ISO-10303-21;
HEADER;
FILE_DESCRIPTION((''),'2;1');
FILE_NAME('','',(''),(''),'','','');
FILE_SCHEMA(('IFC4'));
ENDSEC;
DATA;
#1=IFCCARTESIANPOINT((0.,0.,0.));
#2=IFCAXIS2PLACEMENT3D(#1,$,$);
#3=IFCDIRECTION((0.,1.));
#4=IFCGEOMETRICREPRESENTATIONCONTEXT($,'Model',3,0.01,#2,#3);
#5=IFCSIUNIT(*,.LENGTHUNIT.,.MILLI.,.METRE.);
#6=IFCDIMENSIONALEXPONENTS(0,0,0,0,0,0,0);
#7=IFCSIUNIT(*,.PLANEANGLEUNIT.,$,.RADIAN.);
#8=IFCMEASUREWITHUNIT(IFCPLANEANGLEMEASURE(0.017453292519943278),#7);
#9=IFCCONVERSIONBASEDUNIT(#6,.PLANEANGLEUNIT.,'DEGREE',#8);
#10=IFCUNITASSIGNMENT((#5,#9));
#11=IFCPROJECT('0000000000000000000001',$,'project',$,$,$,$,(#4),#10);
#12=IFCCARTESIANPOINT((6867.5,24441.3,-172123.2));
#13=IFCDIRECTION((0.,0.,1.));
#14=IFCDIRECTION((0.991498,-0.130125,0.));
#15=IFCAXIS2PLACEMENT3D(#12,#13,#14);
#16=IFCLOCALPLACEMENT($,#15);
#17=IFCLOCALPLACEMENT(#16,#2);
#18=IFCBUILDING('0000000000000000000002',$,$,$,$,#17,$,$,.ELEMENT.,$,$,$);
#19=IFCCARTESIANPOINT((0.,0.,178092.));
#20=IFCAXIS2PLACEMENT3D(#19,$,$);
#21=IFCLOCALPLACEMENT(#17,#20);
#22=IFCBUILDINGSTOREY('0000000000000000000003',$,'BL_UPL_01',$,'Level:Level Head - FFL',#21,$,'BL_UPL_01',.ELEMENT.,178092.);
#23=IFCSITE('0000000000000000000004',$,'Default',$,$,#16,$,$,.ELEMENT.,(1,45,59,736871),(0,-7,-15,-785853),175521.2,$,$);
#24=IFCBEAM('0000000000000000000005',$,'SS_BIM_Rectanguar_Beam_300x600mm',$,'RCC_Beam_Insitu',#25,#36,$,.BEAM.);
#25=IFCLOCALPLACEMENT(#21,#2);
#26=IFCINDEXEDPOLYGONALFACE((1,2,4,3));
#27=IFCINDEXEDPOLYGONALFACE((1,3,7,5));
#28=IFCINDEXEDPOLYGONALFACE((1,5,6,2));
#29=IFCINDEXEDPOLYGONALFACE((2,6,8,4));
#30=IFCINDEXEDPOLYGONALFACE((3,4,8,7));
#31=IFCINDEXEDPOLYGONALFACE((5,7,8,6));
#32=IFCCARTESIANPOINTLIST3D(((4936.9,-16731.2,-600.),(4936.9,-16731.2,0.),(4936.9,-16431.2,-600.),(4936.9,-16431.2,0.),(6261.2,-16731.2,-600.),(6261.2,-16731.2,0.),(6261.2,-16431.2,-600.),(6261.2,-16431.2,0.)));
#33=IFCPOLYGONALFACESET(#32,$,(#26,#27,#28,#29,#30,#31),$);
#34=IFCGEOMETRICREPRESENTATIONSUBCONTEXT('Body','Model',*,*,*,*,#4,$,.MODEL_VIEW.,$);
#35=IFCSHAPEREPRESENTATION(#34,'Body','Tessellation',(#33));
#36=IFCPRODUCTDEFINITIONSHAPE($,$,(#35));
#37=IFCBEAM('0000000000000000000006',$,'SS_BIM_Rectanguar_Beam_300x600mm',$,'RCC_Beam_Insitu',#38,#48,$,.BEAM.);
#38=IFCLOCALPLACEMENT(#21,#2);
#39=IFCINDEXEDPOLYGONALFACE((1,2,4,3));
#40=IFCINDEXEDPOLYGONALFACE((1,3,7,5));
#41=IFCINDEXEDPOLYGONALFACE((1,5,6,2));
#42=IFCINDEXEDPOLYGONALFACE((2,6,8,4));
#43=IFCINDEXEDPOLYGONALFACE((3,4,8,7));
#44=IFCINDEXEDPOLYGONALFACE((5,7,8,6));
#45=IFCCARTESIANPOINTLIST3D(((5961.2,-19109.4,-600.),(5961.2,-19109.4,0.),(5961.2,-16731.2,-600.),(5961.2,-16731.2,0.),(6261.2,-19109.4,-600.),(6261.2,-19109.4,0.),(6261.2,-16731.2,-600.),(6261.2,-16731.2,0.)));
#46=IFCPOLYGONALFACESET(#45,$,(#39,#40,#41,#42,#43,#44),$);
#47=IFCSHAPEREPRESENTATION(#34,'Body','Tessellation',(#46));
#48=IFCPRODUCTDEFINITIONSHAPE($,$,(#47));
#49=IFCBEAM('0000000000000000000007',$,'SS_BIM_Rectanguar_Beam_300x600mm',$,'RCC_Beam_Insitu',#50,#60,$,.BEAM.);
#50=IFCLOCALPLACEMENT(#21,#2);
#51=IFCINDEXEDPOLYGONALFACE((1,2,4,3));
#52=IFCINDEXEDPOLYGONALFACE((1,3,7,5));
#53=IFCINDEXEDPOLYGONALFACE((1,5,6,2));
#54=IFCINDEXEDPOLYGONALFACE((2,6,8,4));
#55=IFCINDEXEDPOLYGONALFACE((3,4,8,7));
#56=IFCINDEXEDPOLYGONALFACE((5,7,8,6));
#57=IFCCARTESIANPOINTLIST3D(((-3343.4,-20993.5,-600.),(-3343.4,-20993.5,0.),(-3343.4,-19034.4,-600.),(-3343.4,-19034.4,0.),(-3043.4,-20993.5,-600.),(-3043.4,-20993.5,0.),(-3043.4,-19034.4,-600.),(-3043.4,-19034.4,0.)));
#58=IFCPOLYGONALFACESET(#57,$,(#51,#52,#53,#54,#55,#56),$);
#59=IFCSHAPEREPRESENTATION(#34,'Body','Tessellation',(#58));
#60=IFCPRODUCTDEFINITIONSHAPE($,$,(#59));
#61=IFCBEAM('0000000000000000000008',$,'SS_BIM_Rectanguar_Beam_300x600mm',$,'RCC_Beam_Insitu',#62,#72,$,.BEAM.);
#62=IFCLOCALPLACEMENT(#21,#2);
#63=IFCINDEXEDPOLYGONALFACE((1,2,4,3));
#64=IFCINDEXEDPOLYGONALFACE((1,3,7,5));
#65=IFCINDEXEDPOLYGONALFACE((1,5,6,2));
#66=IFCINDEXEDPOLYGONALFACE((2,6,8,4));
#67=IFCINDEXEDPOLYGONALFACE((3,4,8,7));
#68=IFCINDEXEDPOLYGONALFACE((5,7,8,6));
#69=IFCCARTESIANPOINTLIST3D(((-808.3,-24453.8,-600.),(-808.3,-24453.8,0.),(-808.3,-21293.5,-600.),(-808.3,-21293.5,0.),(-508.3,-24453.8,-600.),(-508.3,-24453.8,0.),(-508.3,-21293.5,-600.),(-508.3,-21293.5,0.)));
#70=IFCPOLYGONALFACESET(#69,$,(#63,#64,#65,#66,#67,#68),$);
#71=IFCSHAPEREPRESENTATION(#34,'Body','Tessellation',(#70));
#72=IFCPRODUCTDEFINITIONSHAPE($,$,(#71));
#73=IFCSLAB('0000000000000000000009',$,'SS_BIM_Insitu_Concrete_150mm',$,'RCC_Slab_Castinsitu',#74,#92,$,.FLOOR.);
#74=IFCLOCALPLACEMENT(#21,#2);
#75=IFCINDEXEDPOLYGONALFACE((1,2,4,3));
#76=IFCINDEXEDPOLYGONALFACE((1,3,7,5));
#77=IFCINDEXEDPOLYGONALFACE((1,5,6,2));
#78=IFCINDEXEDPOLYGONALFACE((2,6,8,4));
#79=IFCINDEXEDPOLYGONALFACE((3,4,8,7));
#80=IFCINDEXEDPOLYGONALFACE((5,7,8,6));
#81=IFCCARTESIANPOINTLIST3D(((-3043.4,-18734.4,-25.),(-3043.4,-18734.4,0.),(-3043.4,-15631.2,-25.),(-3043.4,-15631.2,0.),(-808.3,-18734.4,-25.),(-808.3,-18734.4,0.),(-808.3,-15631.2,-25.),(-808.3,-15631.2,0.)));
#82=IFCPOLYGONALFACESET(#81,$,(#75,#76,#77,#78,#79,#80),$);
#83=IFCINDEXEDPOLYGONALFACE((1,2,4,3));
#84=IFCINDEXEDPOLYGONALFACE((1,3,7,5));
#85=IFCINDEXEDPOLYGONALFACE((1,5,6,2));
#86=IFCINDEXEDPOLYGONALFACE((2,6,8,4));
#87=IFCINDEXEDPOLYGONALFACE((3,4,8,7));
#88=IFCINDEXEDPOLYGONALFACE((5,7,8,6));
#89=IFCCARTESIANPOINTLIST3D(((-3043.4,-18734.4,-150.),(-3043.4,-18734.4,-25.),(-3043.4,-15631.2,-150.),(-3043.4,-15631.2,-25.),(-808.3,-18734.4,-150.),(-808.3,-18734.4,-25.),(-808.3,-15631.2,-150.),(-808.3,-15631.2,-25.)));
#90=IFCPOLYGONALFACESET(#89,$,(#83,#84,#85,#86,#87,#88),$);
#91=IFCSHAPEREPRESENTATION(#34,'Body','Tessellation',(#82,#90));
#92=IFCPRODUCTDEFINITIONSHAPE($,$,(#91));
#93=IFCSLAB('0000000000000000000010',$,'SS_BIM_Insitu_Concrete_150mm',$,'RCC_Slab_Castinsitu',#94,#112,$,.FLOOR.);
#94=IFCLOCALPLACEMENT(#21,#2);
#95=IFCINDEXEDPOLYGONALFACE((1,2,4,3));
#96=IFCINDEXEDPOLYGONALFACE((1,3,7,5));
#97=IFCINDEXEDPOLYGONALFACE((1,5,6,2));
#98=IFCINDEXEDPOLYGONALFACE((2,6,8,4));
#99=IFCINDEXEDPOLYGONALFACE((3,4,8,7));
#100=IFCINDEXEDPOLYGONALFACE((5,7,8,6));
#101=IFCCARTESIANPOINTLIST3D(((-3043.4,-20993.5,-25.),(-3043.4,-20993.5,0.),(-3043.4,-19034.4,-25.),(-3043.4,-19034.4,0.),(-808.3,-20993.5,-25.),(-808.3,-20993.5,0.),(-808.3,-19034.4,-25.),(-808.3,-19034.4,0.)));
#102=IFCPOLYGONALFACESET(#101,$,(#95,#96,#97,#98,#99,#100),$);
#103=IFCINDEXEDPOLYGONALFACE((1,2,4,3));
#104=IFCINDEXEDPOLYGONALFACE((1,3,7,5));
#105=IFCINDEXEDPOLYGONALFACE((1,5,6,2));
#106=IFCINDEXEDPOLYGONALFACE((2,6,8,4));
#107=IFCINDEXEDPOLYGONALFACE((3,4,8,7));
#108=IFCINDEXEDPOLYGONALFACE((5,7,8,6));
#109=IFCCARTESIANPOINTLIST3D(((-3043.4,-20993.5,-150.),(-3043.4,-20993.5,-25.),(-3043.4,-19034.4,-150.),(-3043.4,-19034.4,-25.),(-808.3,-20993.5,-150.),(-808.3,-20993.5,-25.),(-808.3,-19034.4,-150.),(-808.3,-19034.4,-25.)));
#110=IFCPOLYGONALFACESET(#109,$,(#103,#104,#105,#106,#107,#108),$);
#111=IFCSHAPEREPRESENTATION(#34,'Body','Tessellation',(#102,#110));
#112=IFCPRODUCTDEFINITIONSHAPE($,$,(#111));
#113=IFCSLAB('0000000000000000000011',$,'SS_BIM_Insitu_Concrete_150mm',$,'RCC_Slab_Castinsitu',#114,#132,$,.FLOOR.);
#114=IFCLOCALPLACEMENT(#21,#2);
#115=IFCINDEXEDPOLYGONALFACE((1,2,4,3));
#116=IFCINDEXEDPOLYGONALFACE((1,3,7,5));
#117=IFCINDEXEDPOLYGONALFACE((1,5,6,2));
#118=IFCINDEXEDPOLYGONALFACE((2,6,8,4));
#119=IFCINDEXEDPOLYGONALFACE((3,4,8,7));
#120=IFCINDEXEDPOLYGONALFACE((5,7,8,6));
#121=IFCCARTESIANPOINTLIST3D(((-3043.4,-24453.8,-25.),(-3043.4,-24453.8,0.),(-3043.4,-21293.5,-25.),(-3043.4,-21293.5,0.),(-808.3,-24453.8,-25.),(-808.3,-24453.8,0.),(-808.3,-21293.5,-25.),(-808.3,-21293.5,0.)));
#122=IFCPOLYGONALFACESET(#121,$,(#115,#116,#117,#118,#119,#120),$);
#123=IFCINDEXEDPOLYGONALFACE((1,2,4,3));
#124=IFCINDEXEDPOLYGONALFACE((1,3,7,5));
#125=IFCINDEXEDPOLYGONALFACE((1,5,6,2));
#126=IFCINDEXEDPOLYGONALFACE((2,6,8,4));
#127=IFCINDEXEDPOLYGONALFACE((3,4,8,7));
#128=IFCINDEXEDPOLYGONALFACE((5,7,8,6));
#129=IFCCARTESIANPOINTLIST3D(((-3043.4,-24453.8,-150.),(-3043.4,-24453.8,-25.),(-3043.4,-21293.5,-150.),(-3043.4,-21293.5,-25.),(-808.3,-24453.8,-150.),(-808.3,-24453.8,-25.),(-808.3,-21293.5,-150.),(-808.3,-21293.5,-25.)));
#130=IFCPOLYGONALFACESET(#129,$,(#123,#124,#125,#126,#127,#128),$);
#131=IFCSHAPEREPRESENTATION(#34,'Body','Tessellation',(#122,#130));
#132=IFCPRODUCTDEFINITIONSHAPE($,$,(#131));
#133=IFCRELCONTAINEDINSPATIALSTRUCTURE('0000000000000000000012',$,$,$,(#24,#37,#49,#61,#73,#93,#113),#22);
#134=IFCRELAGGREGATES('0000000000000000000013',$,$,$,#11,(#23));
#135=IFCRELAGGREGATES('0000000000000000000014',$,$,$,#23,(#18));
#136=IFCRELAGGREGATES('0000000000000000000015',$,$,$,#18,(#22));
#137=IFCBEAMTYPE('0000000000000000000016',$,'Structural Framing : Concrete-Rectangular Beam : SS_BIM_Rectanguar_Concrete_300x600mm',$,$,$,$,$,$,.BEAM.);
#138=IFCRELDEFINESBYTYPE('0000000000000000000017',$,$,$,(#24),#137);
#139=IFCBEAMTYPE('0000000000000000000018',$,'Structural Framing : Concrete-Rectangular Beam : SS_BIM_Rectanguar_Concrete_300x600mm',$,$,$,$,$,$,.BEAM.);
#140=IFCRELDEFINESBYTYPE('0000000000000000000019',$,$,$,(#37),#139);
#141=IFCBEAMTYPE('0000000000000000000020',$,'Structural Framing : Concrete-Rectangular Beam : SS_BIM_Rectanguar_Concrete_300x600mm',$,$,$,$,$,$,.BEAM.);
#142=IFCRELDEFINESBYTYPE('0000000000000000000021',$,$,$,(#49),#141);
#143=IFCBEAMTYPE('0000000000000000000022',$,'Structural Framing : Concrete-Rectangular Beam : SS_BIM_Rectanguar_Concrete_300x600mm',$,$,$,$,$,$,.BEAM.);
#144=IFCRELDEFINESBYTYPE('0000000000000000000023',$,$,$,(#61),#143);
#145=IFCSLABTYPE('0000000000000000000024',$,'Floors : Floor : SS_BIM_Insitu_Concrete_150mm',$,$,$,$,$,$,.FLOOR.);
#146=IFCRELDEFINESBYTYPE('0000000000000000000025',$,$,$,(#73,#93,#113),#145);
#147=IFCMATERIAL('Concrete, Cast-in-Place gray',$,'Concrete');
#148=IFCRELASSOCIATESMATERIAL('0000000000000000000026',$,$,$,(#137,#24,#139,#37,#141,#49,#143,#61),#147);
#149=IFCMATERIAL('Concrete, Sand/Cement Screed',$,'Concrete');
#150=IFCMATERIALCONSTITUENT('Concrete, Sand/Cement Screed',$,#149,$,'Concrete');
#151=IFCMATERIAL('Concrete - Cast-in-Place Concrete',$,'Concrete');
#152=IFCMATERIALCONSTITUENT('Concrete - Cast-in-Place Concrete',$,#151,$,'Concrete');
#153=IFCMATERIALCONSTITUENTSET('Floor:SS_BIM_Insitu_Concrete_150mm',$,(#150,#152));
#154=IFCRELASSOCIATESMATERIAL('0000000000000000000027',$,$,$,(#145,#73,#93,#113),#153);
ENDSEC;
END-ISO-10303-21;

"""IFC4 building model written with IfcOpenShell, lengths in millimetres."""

from ifc_helpers import new_model, entity, si_unit, converted_unit, direction, frame, origin, place, context, subcontext, project, spatial, indexed_curve, outline, extrude, source, transform, mapped, material, constituent, constituent_set, type_object, type_shapes, element, save


model = new_model("IFC4")

# Units and contexts
model_context = context("Model", 3, precision=0.01, world=origin(), true_north=direction((0.0, 1.0)))
body_context = subcontext(model_context, "Body", "Model", "MODEL_VIEW")
ifc_project = project(units=[si_unit("LENGTHUNIT", "METRE", prefix="MILLI"), converted_unit("PLANEANGLEUNIT", "DEGREE", entity("IfcPlaneAngleMeasure", 0.017453292519943278), si_unit("PLANEANGLEUNIT", "RADIAN"), dimensions=[0, 0, 0, 0, 0, 0, 0])], contexts=[model_context])

# Site, building, storey
site_placement = place(None, frame((6867.5, 24441.3, -172123.2), z_axis=(0.0, 0.0, 1.0), x_axis=(0.991498, -0.130125, 0.0)))
site = spatial("IfcSite", under=ifc_project, at=site_placement, Name="Default", CompositionType="ELEMENT", RefLatitude=(1, 45, 59, 736871), RefLongitude=(0, -7, -15, -785853), RefElevation=175521.2)
building_placement = place(site_placement, origin())
building = spatial("IfcBuilding", under=site, at=building_placement, CompositionType="ELEMENT")
storey_placement = place(building_placement, frame((0.0, 0.0, 178092.0)))
storey = spatial("IfcBuildingStorey", under=building, at=storey_placement, Name="BL_UPL_01", ObjectType="Level:Level Head - FFL", LongName="BL_UPL_01", CompositionType="ELEMENT", Elevation=178092.0)

# Shared definitions
ifc_material_1 = material(Name="Concrete, Cast-in-Place gray", Category="Concrete")

# Beams
beam_type_1 = type_object("IfcBeamType", Name="Structural Framing : Concrete-Rectangular Beam : SS_BIM_Rectanguar_Concrete_300x600mm", PredefinedType="BEAM", material=ifc_material_1)
shared_shape_1 = source(origin(), body_context, "Body", "SweptSolid", [
    extrude(outline(indexed_curve([(-300.0, -150.0), (300.0, -150.0), (300.0, 150.0), (-300.0, 150.0), (-300.0, -150.0)], self_intersect=False)), frame((6261.2, -16581.2, 177792.0), z_axis=(-1.0, 0.0, 0.0), x_axis=(0.0, 0.0, -1.0)), (0.0, 0.0, 1.0), 1324.3),
])
type_shapes(beam_type_1, [shared_shape_1])
beam_1_placement = place(storey_placement, frame((0.0, 0.0, -178092.0)))
element("IfcBeam", 1, at=beam_1_placement, inside=storey, type_object=beam_type_1, material=ifc_material_1, Name="SS_BIM_Rectanguar_Beam_300x600mm", ObjectType="RCC_Beam_Insitu", PredefinedType="BEAM", context=body_context, shape_type="MappedRepresentation", body=[
    mapped(shared_shape_1, transform((0.0, 0.0, 0.0), scale=1.0)),
])
beam_type_2 = type_object("IfcBeamType", Name="Structural Framing : Concrete-Rectangular Beam : SS_BIM_Rectanguar_Concrete_300x600mm", PredefinedType="BEAM", material=ifc_material_1)
shared_shape_2 = source(origin(), body_context, "Body", "SweptSolid", [
    extrude(outline(indexed_curve([(-150.0, -300.0), (150.0, -300.0), (150.0, 300.0), (-150.0, 300.0), (-150.0, -300.0)], self_intersect=False)), frame((6111.2, -16731.2, 177792.0), z_axis=(0.0, -1.0, 0.0), x_axis=(-1.0, 0.0, 0.0)), (0.0, 0.0, 1.0), 2378.2),
])
type_shapes(beam_type_2, [shared_shape_2])
beam_2_placement = place(storey_placement, frame((0.0, 0.0, -178092.0)))
element("IfcBeam", 2, at=beam_2_placement, inside=storey, type_object=beam_type_2, material=ifc_material_1, Name="SS_BIM_Rectanguar_Beam_300x600mm", ObjectType="RCC_Beam_Insitu", PredefinedType="BEAM", context=body_context, shape_type="MappedRepresentation", body=[
    mapped(shared_shape_2, transform((0.0, 0.0, 0.0), scale=1.0)),
])
beam_type_3 = type_object("IfcBeamType", Name="Structural Framing : Concrete-Rectangular Beam : SS_BIM_Rectanguar_Concrete_300x600mm", PredefinedType="BEAM", material=ifc_material_1)
shared_shape_3 = source(origin(), body_context, "Body", "SweptSolid", [
    extrude(outline(indexed_curve([(-150.0, -300.0), (150.0, -300.0), (150.0, 300.0), (-150.0, 300.0), (-150.0, -300.0)], self_intersect=False)), frame((-3193.4, -20993.5, 177792.0), z_axis=(0.0, 1.0, 0.0), x_axis=(-1.0, 0.0, 0.0)), (0.0, 0.0, 1.0), 1959.1),
])
type_shapes(beam_type_3, [shared_shape_3])
beam_3_placement = place(storey_placement, frame((0.0, 0.0, -178092.0)))
element("IfcBeam", 3, at=beam_3_placement, inside=storey, type_object=beam_type_3, material=ifc_material_1, Name="SS_BIM_Rectanguar_Beam_300x600mm", ObjectType="RCC_Beam_Insitu", PredefinedType="BEAM", context=body_context, shape_type="MappedRepresentation", body=[
    mapped(shared_shape_3, transform((0.0, 0.0, 0.0), scale=1.0)),
])
beam_type_4 = type_object("IfcBeamType", Name="Structural Framing : Concrete-Rectangular Beam : SS_BIM_Rectanguar_Concrete_300x600mm", PredefinedType="BEAM", material=ifc_material_1)
shared_shape_4 = source(origin(), body_context, "Body", "SweptSolid", [
    extrude(outline(indexed_curve([(-150.0, -300.0), (150.0, -300.0), (150.0, 300.0), (-150.0, 300.0), (-150.0, -300.0)], self_intersect=False)), frame((-658.3, -24453.8, 177792.0), z_axis=(0.0, 1.0, 0.0), x_axis=(-1.0, 0.0, 0.0)), (0.0, 0.0, 1.0), 3160.3),
])
type_shapes(beam_type_4, [shared_shape_4])
beam_4_placement = place(storey_placement, frame((0.0, 0.0, -178092.0)))
element("IfcBeam", 4, at=beam_4_placement, inside=storey, type_object=beam_type_4, material=ifc_material_1, Name="SS_BIM_Rectanguar_Beam_300x600mm", ObjectType="RCC_Beam_Insitu", PredefinedType="BEAM", context=body_context, shape_type="MappedRepresentation", body=[
    mapped(shared_shape_4, transform((0.0, 0.0, 0.0), scale=1.0)),
])

# Slabs
ifc_material_2 = material(Name="Concrete, Sand/Cement Screed", Category="Concrete")
ifc_material_3 = material(Name="Concrete - Cast-in-Place Concrete", Category="Concrete")
ifc_constituent_1 = constituent(ifc_material_2, Name="Concrete, Sand/Cement Screed", Category="Concrete")
ifc_constituent_2 = constituent(ifc_material_3, Name="Concrete - Cast-in-Place Concrete", Category="Concrete")
ifc_constituent_set_1 = constituent_set(constituents=[ifc_constituent_1, ifc_constituent_2], Name="Floor:SS_BIM_Insitu_Concrete_150mm")
slab_type_1 = type_object("IfcSlabType", Name="Floors : Floor : SS_BIM_Insitu_Concrete_150mm", PredefinedType="FLOOR", material=ifc_constituent_set_1)
slab_1_placement = place(storey_placement, origin())
element("IfcSlab", 5, at=slab_1_placement, inside=storey, type_object=slab_type_1, material=ifc_constituent_set_1, Name="SS_BIM_Insitu_Concrete_150mm", ObjectType="RCC_Slab_Castinsitu", PredefinedType="FLOOR", context=body_context, shape_type="SweptSolid", body=[
    extrude(outline(indexed_curve([(-1117.5, -1551.6), (1117.5, -1551.6), (1117.5, 1551.6), (-1117.5, 1551.6), (-1117.5, -1551.6)], self_intersect=False)), frame((-1925.8, -17182.8, -25.0), z_axis=(0.0, 0.0, 1.0), x_axis=(-1.0, 0.0, 0.0)), (0.0, 0.0, 1.0), 25.0),
    extrude(outline(indexed_curve([(-1117.5, -1551.6), (1117.5, -1551.6), (1117.5, 1551.6), (-1117.5, 1551.6), (-1117.5, -1551.6)], self_intersect=False)), frame((-1925.8, -17182.8, -150.0), z_axis=(0.0, 0.0, 1.0), x_axis=(-1.0, 0.0, 0.0)), (0.0, 0.0, 1.0), 125.0),
])
slab_2_placement = place(storey_placement, origin())
element("IfcSlab", 6, at=slab_2_placement, inside=storey, type_object=slab_type_1, material=ifc_constituent_set_1, Name="SS_BIM_Insitu_Concrete_150mm", ObjectType="RCC_Slab_Castinsitu", PredefinedType="FLOOR", context=body_context, shape_type="SweptSolid", body=[
    extrude(outline(indexed_curve([(-1117.5, -979.6), (1117.5, -979.6), (1117.5, 979.6), (-1117.5, 979.6), (-1117.5, -979.6)], self_intersect=False)), frame((-1925.8, -20013.9, -25.0), z_axis=(0.0, 0.0, 1.0), x_axis=(-1.0, 0.0, 0.0)), (0.0, 0.0, 1.0), 25.0),
    extrude(outline(indexed_curve([(-1117.5, -979.6), (1117.5, -979.6), (1117.5, 979.6), (-1117.5, 979.6), (-1117.5, -979.6)], self_intersect=False)), frame((-1925.8, -20013.9, -150.0), z_axis=(0.0, 0.0, 1.0), x_axis=(-1.0, 0.0, 0.0)), (0.0, 0.0, 1.0), 125.0),
])
slab_3_placement = place(storey_placement, origin())
element("IfcSlab", 7, at=slab_3_placement, inside=storey, type_object=slab_type_1, material=ifc_constituent_set_1, Name="SS_BIM_Insitu_Concrete_150mm", ObjectType="RCC_Slab_Castinsitu", PredefinedType="FLOOR", context=body_context, shape_type="SweptSolid", body=[
    extrude(outline(indexed_curve([(-1117.5, -1580.2), (1117.5, -1580.2), (1117.5, 1580.2), (-1117.5, 1580.2), (-1117.5, -1580.2)], self_intersect=False)), frame((-1925.8, -22873.6, -25.0), z_axis=(0.0, 0.0, 1.0), x_axis=(-1.0, 0.0, 0.0)), (0.0, 0.0, 1.0), 25.0),
    extrude(outline(indexed_curve([(-1117.5, -1580.2), (1117.5, -1580.2), (1117.5, 1580.2), (-1117.5, 1580.2), (-1117.5, -1580.2)], self_intersect=False)), frame((-1925.8, -22873.6, -150.0), z_axis=(0.0, 0.0, 1.0), x_axis=(-1.0, 0.0, 0.0)), (0.0, 0.0, 1.0), 125.0),
])

save(model, "model.ifc")
